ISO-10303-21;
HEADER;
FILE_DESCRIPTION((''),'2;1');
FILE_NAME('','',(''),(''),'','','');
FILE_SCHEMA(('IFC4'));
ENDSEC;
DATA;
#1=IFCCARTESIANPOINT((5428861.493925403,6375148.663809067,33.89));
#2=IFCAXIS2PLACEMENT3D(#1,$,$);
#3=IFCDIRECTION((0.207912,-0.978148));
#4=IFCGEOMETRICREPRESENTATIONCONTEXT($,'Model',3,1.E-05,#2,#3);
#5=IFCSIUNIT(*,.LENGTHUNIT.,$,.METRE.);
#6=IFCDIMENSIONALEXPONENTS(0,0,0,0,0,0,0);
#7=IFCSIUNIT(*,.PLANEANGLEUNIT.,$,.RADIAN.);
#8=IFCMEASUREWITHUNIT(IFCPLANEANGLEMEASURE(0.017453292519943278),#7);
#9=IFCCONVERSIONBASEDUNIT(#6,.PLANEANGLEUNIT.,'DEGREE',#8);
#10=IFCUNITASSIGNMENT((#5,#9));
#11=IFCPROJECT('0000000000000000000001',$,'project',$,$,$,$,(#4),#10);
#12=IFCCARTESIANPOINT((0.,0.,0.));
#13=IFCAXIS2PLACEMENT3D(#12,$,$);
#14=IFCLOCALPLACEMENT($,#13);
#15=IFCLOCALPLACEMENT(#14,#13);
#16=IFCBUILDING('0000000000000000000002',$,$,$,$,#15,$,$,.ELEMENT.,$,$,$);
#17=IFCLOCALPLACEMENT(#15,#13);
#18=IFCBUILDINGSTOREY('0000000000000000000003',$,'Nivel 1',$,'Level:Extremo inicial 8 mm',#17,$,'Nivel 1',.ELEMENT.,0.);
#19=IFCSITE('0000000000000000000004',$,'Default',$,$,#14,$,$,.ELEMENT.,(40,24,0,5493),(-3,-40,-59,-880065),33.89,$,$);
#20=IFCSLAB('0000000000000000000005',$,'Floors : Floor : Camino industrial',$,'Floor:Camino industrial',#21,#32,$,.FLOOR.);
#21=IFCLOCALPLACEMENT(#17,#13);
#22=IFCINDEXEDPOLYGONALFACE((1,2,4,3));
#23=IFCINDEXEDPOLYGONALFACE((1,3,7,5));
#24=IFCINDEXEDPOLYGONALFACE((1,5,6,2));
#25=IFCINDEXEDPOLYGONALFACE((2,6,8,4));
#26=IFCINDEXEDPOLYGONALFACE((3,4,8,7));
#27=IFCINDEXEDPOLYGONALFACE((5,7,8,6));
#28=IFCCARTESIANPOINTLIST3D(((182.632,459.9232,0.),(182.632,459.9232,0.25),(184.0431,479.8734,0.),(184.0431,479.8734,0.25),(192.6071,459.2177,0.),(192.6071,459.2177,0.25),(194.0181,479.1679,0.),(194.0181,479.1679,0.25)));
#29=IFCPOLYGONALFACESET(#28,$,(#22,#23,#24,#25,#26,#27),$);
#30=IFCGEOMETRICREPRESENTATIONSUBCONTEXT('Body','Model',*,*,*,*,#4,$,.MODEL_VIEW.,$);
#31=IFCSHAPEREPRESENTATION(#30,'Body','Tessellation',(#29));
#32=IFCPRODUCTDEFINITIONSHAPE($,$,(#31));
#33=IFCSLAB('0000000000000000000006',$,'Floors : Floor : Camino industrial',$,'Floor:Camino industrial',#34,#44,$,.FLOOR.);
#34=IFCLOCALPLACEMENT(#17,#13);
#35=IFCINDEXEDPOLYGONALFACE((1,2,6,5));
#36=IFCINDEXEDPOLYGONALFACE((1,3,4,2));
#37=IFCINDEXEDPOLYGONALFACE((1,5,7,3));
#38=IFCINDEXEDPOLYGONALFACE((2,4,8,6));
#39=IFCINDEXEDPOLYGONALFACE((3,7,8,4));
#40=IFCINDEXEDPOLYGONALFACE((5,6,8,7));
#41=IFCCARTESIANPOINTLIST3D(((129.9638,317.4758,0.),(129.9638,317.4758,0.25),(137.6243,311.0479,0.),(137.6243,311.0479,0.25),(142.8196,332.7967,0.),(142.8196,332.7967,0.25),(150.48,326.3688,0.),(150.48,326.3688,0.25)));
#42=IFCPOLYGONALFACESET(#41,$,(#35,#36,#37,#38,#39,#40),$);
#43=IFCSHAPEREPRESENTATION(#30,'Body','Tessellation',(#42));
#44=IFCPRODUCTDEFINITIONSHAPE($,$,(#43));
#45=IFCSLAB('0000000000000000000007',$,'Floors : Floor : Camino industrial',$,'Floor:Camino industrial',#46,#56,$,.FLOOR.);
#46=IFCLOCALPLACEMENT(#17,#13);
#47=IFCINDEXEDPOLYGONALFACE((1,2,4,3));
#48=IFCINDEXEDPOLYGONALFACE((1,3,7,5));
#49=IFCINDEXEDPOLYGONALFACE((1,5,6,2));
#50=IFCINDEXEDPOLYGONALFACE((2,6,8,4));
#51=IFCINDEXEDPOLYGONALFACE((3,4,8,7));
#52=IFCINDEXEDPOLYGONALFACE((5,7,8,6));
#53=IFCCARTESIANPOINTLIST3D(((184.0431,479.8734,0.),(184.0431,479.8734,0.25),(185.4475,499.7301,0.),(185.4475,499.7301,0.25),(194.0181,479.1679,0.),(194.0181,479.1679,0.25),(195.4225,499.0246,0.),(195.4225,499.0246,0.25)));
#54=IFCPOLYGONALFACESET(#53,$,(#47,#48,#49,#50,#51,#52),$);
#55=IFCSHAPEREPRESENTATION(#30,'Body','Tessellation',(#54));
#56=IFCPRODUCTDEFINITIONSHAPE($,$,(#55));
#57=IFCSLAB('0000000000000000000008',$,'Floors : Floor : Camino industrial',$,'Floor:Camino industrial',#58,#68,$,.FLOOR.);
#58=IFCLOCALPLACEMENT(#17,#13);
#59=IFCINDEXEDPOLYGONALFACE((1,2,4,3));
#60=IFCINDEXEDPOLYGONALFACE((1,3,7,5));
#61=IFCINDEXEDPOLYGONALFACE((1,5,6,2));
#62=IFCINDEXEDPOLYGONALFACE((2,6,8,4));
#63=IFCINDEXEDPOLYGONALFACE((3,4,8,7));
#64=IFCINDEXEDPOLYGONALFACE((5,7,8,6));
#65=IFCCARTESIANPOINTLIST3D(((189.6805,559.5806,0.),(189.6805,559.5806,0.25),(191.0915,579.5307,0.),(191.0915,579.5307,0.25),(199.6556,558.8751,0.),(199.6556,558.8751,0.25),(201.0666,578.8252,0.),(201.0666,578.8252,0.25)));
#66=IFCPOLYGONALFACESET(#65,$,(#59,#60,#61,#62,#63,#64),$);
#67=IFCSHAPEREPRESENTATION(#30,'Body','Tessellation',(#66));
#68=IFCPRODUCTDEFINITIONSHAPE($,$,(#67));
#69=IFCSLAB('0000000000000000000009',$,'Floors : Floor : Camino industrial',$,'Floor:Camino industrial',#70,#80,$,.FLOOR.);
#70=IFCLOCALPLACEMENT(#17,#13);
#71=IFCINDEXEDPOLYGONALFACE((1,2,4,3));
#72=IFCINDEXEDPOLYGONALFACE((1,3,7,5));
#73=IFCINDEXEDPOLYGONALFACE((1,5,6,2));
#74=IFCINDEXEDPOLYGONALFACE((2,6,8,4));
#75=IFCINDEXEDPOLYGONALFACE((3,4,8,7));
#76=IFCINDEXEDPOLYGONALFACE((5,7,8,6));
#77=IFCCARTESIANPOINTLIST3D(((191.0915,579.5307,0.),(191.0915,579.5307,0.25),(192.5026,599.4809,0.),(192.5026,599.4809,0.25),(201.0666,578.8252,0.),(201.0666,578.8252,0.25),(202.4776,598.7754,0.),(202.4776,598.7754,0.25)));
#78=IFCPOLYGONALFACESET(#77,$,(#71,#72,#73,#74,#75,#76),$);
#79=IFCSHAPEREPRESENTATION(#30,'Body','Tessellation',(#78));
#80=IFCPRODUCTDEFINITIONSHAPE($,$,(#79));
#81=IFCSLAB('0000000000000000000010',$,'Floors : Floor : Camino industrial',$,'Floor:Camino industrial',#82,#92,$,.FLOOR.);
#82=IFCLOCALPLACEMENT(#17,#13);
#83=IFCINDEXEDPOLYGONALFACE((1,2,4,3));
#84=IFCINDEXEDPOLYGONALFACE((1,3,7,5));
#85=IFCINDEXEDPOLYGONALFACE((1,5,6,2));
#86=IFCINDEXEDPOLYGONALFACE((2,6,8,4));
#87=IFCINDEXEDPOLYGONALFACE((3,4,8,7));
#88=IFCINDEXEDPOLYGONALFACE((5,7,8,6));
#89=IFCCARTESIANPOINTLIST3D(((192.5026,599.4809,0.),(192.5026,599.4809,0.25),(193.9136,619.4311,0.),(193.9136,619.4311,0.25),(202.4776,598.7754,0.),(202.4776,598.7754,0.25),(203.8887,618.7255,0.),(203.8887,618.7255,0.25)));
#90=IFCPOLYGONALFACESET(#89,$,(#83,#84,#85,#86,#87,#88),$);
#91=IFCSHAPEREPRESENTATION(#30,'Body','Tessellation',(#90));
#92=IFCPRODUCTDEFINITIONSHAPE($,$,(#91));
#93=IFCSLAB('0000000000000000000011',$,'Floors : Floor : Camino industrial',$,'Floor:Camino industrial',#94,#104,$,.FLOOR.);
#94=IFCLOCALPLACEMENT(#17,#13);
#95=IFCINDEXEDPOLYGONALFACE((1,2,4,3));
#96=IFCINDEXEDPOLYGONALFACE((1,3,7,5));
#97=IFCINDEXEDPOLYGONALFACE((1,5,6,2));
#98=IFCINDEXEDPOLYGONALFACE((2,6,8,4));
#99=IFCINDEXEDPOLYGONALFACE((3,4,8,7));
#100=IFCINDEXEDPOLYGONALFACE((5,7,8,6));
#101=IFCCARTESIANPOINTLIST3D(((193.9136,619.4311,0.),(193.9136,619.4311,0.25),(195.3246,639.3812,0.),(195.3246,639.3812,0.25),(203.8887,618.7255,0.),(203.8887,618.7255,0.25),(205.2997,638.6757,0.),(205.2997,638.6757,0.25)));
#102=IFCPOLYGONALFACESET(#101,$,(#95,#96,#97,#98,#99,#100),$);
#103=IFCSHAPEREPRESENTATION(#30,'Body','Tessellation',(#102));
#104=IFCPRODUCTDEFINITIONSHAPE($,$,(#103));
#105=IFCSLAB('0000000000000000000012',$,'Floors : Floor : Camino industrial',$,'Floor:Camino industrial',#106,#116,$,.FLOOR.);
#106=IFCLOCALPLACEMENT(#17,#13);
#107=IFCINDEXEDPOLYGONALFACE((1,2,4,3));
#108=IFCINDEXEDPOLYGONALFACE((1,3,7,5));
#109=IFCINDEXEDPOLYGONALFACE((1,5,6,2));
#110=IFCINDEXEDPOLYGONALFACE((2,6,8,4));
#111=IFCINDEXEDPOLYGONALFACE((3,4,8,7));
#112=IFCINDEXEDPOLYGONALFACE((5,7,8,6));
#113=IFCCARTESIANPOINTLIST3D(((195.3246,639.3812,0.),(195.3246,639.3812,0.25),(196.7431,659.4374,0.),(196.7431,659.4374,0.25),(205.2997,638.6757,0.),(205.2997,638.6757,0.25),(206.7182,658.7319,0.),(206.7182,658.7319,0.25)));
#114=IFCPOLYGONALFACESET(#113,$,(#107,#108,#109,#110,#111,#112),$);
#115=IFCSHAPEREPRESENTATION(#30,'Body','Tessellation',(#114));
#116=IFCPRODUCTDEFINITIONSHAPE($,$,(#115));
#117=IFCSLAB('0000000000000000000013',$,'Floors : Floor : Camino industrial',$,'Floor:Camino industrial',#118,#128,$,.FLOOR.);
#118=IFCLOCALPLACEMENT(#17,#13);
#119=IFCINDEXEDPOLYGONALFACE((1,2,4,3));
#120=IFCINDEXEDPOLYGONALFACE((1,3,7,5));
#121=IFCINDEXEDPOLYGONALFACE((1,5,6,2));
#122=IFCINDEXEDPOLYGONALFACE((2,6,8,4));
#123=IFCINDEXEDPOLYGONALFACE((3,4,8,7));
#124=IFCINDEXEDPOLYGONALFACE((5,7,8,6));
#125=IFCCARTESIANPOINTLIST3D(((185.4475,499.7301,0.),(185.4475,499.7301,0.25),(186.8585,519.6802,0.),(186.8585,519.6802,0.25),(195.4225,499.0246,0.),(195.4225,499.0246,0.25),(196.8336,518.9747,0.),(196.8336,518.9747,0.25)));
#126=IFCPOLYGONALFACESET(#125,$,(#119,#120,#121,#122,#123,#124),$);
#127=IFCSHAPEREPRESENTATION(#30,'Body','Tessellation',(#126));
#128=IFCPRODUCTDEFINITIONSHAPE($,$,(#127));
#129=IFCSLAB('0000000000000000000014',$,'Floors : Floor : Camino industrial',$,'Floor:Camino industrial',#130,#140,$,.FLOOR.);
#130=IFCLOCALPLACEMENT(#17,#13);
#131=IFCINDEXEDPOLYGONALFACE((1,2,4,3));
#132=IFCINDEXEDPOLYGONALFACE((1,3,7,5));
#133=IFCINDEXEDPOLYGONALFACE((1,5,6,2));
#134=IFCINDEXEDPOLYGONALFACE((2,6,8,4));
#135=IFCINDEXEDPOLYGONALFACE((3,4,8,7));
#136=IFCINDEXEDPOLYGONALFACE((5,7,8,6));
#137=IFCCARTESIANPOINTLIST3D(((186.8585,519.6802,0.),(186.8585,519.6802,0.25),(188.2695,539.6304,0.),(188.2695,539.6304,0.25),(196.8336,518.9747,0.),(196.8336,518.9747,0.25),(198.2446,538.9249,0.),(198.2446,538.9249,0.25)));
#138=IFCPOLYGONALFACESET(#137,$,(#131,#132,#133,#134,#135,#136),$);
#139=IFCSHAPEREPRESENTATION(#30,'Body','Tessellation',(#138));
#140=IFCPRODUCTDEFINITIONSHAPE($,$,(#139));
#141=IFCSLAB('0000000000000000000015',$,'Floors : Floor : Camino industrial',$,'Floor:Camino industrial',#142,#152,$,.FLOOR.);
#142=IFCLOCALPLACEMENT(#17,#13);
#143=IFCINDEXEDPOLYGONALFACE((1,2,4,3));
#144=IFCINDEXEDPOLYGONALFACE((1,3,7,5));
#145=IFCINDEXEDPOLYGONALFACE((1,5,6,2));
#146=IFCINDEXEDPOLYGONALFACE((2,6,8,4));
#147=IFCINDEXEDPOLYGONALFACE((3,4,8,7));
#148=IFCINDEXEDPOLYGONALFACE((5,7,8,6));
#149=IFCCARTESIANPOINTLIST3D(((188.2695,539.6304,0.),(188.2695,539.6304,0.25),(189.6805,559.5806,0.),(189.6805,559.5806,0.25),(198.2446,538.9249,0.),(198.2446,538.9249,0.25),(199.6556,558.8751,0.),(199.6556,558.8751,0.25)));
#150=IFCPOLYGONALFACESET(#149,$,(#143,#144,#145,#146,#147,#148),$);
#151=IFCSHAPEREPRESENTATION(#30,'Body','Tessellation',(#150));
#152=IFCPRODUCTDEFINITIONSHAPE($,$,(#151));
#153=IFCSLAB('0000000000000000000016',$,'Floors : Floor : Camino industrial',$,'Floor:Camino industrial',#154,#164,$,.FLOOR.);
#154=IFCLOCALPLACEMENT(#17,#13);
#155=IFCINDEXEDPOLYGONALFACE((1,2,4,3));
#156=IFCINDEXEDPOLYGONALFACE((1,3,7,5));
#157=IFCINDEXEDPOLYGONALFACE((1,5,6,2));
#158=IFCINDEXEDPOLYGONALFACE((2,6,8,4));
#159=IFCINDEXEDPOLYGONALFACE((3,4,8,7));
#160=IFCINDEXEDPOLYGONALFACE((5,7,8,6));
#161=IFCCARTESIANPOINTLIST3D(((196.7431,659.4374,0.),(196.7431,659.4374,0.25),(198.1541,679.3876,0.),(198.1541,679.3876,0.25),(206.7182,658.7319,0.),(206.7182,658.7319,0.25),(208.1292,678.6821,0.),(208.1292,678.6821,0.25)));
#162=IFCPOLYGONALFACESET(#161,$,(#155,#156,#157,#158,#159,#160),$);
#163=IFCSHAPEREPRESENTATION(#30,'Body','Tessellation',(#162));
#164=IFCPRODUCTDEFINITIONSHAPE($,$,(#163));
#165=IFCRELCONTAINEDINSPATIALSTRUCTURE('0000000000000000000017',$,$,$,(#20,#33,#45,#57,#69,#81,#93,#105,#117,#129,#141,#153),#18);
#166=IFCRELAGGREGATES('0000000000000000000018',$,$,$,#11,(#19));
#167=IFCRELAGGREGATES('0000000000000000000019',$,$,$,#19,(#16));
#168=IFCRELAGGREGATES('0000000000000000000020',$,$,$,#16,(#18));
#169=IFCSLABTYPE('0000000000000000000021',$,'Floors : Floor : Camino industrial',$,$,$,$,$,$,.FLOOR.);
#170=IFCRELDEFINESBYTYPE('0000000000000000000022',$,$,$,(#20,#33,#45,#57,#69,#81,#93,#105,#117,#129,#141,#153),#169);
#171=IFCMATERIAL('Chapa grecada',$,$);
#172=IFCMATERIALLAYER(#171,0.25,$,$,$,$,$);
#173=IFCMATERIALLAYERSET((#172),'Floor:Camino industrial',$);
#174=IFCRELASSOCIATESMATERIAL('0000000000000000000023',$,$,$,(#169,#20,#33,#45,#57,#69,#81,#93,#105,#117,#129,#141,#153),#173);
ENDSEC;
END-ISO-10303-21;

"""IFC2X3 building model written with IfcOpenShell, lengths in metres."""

from ifc_helpers import new_model, entity, si_unit, converted_unit, direction, frame, frame_2d, origin, origin_2d_with_axis, place, context, subcontext, project, spatial, rectangle, extrude, material, layer, layer_set, layer_usage, type_object, element, save


model = new_model("IFC2X3")

# Units and contexts
model_context = context("Model", 3, precision=1e-05, world=frame((5428861.493925403, 6375148.663809067, 33.89)), true_north=direction((0.207912, -0.978148)))
body_context = subcontext(model_context, "Body", "Model", "MODEL_VIEW")
ifc_project = project(units=[si_unit("LENGTHUNIT", "METRE"), converted_unit("PLANEANGLEUNIT", "DEGREE", entity("IfcPlaneAngleMeasure", 0.017453292519943278), si_unit("PLANEANGLEUNIT", "RADIAN"), dimensions=[0, 0, 0, 0, 0, 0, 0])], contexts=[model_context])

# Site, building, storey
site_placement = place(None, origin())
site = spatial("IfcSite", under=ifc_project, at=site_placement, Name="Default", CompositionType="ELEMENT", RefLatitude=(40, 24, 0, 5493), RefLongitude=(-3, -40, -59, -880065), RefElevation=33.89)
building_placement = place(site_placement, origin())
building = spatial("IfcBuilding", under=site, at=building_placement, CompositionType="ELEMENT")
storey_placement = place(building_placement, origin())
storey = spatial("IfcBuildingStorey", under=building, at=storey_placement, Name="Nivel 1", ObjectType="Level:Extremo inicial 8 mm", LongName="Nivel 1", CompositionType="ELEMENT", Elevation=0.0)

# Slabs
ifc_material_1 = material(Name="Chapa grecada")
ifc_layer_1 = layer(ifc_material_1, 0.25)
ifc_layer_set_1 = layer_set([ifc_layer_1], Name="Floor:Camino industrial")
slab_type_1 = type_object("IfcSlabType", Name="Floors : Floor : Camino industrial", PredefinedType="FLOOR", material=ifc_layer_set_1)
ifc_layer_usage_1 = layer_usage(ifc_layer_set_1, "AXIS3", "POSITIVE", 0.0)
slab_1_placement = place(storey_placement, origin())
element("IfcSlab", 1, at=slab_1_placement, inside=storey, type_object=slab_type_1, material=ifc_layer_usage_1, Name="Floors : Floor : Camino industrial", ObjectType="Floor:Camino industrial", PredefinedType="FLOOR", context=body_context, shape_type="SweptSolid", body=[
    extrude(rectangle(XDim=20.0, YDim=10.0, at=frame_2d((0.0, 0.0), x_axis=(1.0, 0.0))), frame((188.3251, 469.5455, 0.25), z_axis=(0.0, 0.0, -1.0), x_axis=(-0.070551, -0.997508, 0.0)), (0.0, 0.0, 1.0), 0.25),
])
ifc_layer_usage_2 = layer_usage(ifc_layer_set_1, "AXIS3", "POSITIVE", 0.0)
slab_2_placement = place(storey_placement, origin())
element("IfcSlab", 2, at=slab_2_placement, inside=storey, type_object=slab_type_1, material=ifc_layer_usage_2, Name="Floors : Floor : Camino industrial", ObjectType="Floor:Camino industrial", PredefinedType="FLOOR", context=body_context, shape_type="SweptSolid", body=[
    extrude(rectangle(XDim=20.0, YDim=10.0, at=frame_2d((0.0, 0.0), x_axis=(1.0, 0.0))), frame((140.2219, 321.9223, 0.25), z_axis=(0.0, 0.0, -1.0), x_axis=(-0.642788, -0.766044, 0.0)), (0.0, 0.0, 1.0), 0.25),
])
ifc_layer_usage_3 = layer_usage(ifc_layer_set_1, "AXIS3", "POSITIVE", 0.0)
slab_3_placement = place(storey_placement, origin())
element("IfcSlab", 3, at=slab_3_placement, inside=storey, type_object=slab_type_1, material=ifc_layer_usage_3, Name="Floors : Floor : Camino industrial", ObjectType="Floor:Camino industrial", PredefinedType="FLOOR", context=body_context, shape_type="SweptSolid", body=[
    extrude(rectangle(XDim=19.9063, YDim=10.0, at=origin_2d_with_axis()), frame((189.7328, 489.449, 0.25), z_axis=(0.0, 0.0, -1.0), x_axis=(-0.070551, -0.997508, 0.0)), (0.0, 0.0, 1.0), 0.25),
])
ifc_layer_usage_4 = layer_usage(ifc_layer_set_1, "AXIS3", "POSITIVE", 0.0)
slab_4_placement = place(storey_placement, origin())
element("IfcSlab", 4, at=slab_4_placement, inside=storey, type_object=slab_type_1, material=ifc_layer_usage_4, Name="Floors : Floor : Camino industrial", ObjectType="Floor:Camino industrial", PredefinedType="FLOOR", context=body_context, shape_type="SweptSolid", body=[
    extrude(rectangle(XDim=20.0, YDim=10.0, at=frame_2d((0.0, 0.0), x_axis=(1.0, 0.0))), frame((195.3736, 569.2029, 0.25), z_axis=(0.0, 0.0, -1.0), x_axis=(-0.070551, -0.997508, 0.0)), (0.0, 0.0, 1.0), 0.25),
])
ifc_layer_usage_5 = layer_usage(ifc_layer_set_1, "AXIS3", "POSITIVE", 0.0)
slab_5_placement = place(storey_placement, origin())
element("IfcSlab", 5, at=slab_5_placement, inside=storey, type_object=slab_type_1, material=ifc_layer_usage_5, Name="Floors : Floor : Camino industrial", ObjectType="Floor:Camino industrial", PredefinedType="FLOOR", context=body_context, shape_type="SweptSolid", body=[
    extrude(rectangle(XDim=20.0, YDim=10.0, at=frame_2d((0.0, 0.0), x_axis=(1.0, 0.0))), frame((196.7846, 589.1531, 0.25), z_axis=(0.0, 0.0, -1.0), x_axis=(-0.070551, -0.997508, 0.0)), (0.0, 0.0, 1.0), 0.25),
])
ifc_layer_usage_6 = layer_usage(ifc_layer_set_1, "AXIS3", "POSITIVE", 0.0)
slab_6_placement = place(storey_placement, origin())
element("IfcSlab", 6, at=slab_6_placement, inside=storey, type_object=slab_type_1, material=ifc_layer_usage_6, Name="Floors : Floor : Camino industrial", ObjectType="Floor:Camino industrial", PredefinedType="FLOOR", context=body_context, shape_type="SweptSolid", body=[
    extrude(rectangle(XDim=20.0, YDim=10.0, at=frame_2d((0.0, 0.0), x_axis=(1.0, 0.0))), frame((198.1956, 609.1032, 0.25), z_axis=(0.0, 0.0, -1.0), x_axis=(-0.070551, -0.997508, 0.0)), (0.0, 0.0, 1.0), 0.25),
])
ifc_layer_usage_7 = layer_usage(ifc_layer_set_1, "AXIS3", "POSITIVE", 0.0)
slab_7_placement = place(storey_placement, origin())
element("IfcSlab", 7, at=slab_7_placement, inside=storey, type_object=slab_type_1, material=ifc_layer_usage_7, Name="Floors : Floor : Camino industrial", ObjectType="Floor:Camino industrial", PredefinedType="FLOOR", context=body_context, shape_type="SweptSolid", body=[
    extrude(rectangle(XDim=20.0, YDim=10.0, at=frame_2d((0.0, 0.0), x_axis=(1.0, 0.0))), frame((199.6066, 629.0534, 0.25), z_axis=(0.0, 0.0, -1.0), x_axis=(-0.070551, -0.997508, 0.0)), (0.0, 0.0, 1.0), 0.25),
])
ifc_layer_usage_8 = layer_usage(ifc_layer_set_1, "AXIS3", "POSITIVE", 0.0)
slab_8_placement = place(storey_placement, origin())
element("IfcSlab", 8, at=slab_8_placement, inside=storey, type_object=slab_type_1, material=ifc_layer_usage_8, Name="Floors : Floor : Camino industrial", ObjectType="Floor:Camino industrial", PredefinedType="FLOOR", context=body_context, shape_type="SweptSolid", body=[
    extrude(rectangle(XDim=20.1063, YDim=10.0, at=origin_2d_with_axis()), frame((201.0214, 649.0566, 0.25), z_axis=(0.0, 0.0, -1.0), x_axis=(-0.070551, -0.997508, 0.0)), (0.0, 0.0, 1.0), 0.25),
])
ifc_layer_usage_9 = layer_usage(ifc_layer_set_1, "AXIS3", "POSITIVE", 0.0)
slab_9_placement = place(storey_placement, origin())
element("IfcSlab", 9, at=slab_9_placement, inside=storey, type_object=slab_type_1, material=ifc_layer_usage_9, Name="Floors : Floor : Camino industrial", ObjectType="Floor:Camino industrial", PredefinedType="FLOOR", context=body_context, shape_type="SweptSolid", body=[
    extrude(rectangle(XDim=20.0, YDim=10.0, at=frame_2d((0.0, 0.0), x_axis=(1.0, 0.0))), frame((191.1405, 509.3524, 0.25), z_axis=(0.0, 0.0, -1.0), x_axis=(-0.070551, -0.997508, 0.0)), (0.0, 0.0, 1.0), 0.25),
])
ifc_layer_usage_10 = layer_usage(ifc_layer_set_1, "AXIS3", "POSITIVE", 0.0)
slab_10_placement = place(storey_placement, origin())
element("IfcSlab", 10, at=slab_10_placement, inside=storey, type_object=slab_type_1, material=ifc_layer_usage_10, Name="Floors : Floor : Camino industrial", ObjectType="Floor:Camino industrial", PredefinedType="FLOOR", context=body_context, shape_type="SweptSolid", body=[
    extrude(rectangle(XDim=20.0, YDim=10.0, at=frame_2d((0.0, 0.0), x_axis=(1.0, 0.0))), frame((192.5515, 529.3026, 0.25), z_axis=(0.0, 0.0, -1.0), x_axis=(-0.070551, -0.997508, 0.0)), (0.0, 0.0, 1.0), 0.25),
])
ifc_layer_usage_11 = layer_usage(ifc_layer_set_1, "AXIS3", "POSITIVE", 0.0)
slab_11_placement = place(storey_placement, origin())
element("IfcSlab", 11, at=slab_11_placement, inside=storey, type_object=slab_type_1, material=ifc_layer_usage_11, Name="Floors : Floor : Camino industrial", ObjectType="Floor:Camino industrial", PredefinedType="FLOOR", context=body_context, shape_type="SweptSolid", body=[
    extrude(rectangle(XDim=20.0, YDim=10.0, at=origin_2d_with_axis()), frame((193.9626, 549.2527, 0.25), z_axis=(0.0, 0.0, -1.0), x_axis=(-0.070551, -0.997508, 0.0)), (0.0, 0.0, 1.0), 0.25),
])
ifc_layer_usage_12 = layer_usage(ifc_layer_set_1, "AXIS3", "POSITIVE", 0.0)
slab_12_placement = place(storey_placement, origin())
element("IfcSlab", 12, at=slab_12_placement, inside=storey, type_object=slab_type_1, material=ifc_layer_usage_12, Name="Floors : Floor : Camino industrial", ObjectType="Floor:Camino industrial", PredefinedType="FLOOR", context=body_context, shape_type="SweptSolid", body=[
    extrude(rectangle(XDim=20.0, YDim=10.0, at=frame_2d((0.0, 0.0), x_axis=(1.0, 0.0))), frame((202.4362, 669.0597, 0.25), z_axis=(0.0, 0.0, -1.0), x_axis=(-0.070551, -0.997508, 0.0)), (0.0, 0.0, 1.0), 0.25),
])

save(model, "model.ifc")
